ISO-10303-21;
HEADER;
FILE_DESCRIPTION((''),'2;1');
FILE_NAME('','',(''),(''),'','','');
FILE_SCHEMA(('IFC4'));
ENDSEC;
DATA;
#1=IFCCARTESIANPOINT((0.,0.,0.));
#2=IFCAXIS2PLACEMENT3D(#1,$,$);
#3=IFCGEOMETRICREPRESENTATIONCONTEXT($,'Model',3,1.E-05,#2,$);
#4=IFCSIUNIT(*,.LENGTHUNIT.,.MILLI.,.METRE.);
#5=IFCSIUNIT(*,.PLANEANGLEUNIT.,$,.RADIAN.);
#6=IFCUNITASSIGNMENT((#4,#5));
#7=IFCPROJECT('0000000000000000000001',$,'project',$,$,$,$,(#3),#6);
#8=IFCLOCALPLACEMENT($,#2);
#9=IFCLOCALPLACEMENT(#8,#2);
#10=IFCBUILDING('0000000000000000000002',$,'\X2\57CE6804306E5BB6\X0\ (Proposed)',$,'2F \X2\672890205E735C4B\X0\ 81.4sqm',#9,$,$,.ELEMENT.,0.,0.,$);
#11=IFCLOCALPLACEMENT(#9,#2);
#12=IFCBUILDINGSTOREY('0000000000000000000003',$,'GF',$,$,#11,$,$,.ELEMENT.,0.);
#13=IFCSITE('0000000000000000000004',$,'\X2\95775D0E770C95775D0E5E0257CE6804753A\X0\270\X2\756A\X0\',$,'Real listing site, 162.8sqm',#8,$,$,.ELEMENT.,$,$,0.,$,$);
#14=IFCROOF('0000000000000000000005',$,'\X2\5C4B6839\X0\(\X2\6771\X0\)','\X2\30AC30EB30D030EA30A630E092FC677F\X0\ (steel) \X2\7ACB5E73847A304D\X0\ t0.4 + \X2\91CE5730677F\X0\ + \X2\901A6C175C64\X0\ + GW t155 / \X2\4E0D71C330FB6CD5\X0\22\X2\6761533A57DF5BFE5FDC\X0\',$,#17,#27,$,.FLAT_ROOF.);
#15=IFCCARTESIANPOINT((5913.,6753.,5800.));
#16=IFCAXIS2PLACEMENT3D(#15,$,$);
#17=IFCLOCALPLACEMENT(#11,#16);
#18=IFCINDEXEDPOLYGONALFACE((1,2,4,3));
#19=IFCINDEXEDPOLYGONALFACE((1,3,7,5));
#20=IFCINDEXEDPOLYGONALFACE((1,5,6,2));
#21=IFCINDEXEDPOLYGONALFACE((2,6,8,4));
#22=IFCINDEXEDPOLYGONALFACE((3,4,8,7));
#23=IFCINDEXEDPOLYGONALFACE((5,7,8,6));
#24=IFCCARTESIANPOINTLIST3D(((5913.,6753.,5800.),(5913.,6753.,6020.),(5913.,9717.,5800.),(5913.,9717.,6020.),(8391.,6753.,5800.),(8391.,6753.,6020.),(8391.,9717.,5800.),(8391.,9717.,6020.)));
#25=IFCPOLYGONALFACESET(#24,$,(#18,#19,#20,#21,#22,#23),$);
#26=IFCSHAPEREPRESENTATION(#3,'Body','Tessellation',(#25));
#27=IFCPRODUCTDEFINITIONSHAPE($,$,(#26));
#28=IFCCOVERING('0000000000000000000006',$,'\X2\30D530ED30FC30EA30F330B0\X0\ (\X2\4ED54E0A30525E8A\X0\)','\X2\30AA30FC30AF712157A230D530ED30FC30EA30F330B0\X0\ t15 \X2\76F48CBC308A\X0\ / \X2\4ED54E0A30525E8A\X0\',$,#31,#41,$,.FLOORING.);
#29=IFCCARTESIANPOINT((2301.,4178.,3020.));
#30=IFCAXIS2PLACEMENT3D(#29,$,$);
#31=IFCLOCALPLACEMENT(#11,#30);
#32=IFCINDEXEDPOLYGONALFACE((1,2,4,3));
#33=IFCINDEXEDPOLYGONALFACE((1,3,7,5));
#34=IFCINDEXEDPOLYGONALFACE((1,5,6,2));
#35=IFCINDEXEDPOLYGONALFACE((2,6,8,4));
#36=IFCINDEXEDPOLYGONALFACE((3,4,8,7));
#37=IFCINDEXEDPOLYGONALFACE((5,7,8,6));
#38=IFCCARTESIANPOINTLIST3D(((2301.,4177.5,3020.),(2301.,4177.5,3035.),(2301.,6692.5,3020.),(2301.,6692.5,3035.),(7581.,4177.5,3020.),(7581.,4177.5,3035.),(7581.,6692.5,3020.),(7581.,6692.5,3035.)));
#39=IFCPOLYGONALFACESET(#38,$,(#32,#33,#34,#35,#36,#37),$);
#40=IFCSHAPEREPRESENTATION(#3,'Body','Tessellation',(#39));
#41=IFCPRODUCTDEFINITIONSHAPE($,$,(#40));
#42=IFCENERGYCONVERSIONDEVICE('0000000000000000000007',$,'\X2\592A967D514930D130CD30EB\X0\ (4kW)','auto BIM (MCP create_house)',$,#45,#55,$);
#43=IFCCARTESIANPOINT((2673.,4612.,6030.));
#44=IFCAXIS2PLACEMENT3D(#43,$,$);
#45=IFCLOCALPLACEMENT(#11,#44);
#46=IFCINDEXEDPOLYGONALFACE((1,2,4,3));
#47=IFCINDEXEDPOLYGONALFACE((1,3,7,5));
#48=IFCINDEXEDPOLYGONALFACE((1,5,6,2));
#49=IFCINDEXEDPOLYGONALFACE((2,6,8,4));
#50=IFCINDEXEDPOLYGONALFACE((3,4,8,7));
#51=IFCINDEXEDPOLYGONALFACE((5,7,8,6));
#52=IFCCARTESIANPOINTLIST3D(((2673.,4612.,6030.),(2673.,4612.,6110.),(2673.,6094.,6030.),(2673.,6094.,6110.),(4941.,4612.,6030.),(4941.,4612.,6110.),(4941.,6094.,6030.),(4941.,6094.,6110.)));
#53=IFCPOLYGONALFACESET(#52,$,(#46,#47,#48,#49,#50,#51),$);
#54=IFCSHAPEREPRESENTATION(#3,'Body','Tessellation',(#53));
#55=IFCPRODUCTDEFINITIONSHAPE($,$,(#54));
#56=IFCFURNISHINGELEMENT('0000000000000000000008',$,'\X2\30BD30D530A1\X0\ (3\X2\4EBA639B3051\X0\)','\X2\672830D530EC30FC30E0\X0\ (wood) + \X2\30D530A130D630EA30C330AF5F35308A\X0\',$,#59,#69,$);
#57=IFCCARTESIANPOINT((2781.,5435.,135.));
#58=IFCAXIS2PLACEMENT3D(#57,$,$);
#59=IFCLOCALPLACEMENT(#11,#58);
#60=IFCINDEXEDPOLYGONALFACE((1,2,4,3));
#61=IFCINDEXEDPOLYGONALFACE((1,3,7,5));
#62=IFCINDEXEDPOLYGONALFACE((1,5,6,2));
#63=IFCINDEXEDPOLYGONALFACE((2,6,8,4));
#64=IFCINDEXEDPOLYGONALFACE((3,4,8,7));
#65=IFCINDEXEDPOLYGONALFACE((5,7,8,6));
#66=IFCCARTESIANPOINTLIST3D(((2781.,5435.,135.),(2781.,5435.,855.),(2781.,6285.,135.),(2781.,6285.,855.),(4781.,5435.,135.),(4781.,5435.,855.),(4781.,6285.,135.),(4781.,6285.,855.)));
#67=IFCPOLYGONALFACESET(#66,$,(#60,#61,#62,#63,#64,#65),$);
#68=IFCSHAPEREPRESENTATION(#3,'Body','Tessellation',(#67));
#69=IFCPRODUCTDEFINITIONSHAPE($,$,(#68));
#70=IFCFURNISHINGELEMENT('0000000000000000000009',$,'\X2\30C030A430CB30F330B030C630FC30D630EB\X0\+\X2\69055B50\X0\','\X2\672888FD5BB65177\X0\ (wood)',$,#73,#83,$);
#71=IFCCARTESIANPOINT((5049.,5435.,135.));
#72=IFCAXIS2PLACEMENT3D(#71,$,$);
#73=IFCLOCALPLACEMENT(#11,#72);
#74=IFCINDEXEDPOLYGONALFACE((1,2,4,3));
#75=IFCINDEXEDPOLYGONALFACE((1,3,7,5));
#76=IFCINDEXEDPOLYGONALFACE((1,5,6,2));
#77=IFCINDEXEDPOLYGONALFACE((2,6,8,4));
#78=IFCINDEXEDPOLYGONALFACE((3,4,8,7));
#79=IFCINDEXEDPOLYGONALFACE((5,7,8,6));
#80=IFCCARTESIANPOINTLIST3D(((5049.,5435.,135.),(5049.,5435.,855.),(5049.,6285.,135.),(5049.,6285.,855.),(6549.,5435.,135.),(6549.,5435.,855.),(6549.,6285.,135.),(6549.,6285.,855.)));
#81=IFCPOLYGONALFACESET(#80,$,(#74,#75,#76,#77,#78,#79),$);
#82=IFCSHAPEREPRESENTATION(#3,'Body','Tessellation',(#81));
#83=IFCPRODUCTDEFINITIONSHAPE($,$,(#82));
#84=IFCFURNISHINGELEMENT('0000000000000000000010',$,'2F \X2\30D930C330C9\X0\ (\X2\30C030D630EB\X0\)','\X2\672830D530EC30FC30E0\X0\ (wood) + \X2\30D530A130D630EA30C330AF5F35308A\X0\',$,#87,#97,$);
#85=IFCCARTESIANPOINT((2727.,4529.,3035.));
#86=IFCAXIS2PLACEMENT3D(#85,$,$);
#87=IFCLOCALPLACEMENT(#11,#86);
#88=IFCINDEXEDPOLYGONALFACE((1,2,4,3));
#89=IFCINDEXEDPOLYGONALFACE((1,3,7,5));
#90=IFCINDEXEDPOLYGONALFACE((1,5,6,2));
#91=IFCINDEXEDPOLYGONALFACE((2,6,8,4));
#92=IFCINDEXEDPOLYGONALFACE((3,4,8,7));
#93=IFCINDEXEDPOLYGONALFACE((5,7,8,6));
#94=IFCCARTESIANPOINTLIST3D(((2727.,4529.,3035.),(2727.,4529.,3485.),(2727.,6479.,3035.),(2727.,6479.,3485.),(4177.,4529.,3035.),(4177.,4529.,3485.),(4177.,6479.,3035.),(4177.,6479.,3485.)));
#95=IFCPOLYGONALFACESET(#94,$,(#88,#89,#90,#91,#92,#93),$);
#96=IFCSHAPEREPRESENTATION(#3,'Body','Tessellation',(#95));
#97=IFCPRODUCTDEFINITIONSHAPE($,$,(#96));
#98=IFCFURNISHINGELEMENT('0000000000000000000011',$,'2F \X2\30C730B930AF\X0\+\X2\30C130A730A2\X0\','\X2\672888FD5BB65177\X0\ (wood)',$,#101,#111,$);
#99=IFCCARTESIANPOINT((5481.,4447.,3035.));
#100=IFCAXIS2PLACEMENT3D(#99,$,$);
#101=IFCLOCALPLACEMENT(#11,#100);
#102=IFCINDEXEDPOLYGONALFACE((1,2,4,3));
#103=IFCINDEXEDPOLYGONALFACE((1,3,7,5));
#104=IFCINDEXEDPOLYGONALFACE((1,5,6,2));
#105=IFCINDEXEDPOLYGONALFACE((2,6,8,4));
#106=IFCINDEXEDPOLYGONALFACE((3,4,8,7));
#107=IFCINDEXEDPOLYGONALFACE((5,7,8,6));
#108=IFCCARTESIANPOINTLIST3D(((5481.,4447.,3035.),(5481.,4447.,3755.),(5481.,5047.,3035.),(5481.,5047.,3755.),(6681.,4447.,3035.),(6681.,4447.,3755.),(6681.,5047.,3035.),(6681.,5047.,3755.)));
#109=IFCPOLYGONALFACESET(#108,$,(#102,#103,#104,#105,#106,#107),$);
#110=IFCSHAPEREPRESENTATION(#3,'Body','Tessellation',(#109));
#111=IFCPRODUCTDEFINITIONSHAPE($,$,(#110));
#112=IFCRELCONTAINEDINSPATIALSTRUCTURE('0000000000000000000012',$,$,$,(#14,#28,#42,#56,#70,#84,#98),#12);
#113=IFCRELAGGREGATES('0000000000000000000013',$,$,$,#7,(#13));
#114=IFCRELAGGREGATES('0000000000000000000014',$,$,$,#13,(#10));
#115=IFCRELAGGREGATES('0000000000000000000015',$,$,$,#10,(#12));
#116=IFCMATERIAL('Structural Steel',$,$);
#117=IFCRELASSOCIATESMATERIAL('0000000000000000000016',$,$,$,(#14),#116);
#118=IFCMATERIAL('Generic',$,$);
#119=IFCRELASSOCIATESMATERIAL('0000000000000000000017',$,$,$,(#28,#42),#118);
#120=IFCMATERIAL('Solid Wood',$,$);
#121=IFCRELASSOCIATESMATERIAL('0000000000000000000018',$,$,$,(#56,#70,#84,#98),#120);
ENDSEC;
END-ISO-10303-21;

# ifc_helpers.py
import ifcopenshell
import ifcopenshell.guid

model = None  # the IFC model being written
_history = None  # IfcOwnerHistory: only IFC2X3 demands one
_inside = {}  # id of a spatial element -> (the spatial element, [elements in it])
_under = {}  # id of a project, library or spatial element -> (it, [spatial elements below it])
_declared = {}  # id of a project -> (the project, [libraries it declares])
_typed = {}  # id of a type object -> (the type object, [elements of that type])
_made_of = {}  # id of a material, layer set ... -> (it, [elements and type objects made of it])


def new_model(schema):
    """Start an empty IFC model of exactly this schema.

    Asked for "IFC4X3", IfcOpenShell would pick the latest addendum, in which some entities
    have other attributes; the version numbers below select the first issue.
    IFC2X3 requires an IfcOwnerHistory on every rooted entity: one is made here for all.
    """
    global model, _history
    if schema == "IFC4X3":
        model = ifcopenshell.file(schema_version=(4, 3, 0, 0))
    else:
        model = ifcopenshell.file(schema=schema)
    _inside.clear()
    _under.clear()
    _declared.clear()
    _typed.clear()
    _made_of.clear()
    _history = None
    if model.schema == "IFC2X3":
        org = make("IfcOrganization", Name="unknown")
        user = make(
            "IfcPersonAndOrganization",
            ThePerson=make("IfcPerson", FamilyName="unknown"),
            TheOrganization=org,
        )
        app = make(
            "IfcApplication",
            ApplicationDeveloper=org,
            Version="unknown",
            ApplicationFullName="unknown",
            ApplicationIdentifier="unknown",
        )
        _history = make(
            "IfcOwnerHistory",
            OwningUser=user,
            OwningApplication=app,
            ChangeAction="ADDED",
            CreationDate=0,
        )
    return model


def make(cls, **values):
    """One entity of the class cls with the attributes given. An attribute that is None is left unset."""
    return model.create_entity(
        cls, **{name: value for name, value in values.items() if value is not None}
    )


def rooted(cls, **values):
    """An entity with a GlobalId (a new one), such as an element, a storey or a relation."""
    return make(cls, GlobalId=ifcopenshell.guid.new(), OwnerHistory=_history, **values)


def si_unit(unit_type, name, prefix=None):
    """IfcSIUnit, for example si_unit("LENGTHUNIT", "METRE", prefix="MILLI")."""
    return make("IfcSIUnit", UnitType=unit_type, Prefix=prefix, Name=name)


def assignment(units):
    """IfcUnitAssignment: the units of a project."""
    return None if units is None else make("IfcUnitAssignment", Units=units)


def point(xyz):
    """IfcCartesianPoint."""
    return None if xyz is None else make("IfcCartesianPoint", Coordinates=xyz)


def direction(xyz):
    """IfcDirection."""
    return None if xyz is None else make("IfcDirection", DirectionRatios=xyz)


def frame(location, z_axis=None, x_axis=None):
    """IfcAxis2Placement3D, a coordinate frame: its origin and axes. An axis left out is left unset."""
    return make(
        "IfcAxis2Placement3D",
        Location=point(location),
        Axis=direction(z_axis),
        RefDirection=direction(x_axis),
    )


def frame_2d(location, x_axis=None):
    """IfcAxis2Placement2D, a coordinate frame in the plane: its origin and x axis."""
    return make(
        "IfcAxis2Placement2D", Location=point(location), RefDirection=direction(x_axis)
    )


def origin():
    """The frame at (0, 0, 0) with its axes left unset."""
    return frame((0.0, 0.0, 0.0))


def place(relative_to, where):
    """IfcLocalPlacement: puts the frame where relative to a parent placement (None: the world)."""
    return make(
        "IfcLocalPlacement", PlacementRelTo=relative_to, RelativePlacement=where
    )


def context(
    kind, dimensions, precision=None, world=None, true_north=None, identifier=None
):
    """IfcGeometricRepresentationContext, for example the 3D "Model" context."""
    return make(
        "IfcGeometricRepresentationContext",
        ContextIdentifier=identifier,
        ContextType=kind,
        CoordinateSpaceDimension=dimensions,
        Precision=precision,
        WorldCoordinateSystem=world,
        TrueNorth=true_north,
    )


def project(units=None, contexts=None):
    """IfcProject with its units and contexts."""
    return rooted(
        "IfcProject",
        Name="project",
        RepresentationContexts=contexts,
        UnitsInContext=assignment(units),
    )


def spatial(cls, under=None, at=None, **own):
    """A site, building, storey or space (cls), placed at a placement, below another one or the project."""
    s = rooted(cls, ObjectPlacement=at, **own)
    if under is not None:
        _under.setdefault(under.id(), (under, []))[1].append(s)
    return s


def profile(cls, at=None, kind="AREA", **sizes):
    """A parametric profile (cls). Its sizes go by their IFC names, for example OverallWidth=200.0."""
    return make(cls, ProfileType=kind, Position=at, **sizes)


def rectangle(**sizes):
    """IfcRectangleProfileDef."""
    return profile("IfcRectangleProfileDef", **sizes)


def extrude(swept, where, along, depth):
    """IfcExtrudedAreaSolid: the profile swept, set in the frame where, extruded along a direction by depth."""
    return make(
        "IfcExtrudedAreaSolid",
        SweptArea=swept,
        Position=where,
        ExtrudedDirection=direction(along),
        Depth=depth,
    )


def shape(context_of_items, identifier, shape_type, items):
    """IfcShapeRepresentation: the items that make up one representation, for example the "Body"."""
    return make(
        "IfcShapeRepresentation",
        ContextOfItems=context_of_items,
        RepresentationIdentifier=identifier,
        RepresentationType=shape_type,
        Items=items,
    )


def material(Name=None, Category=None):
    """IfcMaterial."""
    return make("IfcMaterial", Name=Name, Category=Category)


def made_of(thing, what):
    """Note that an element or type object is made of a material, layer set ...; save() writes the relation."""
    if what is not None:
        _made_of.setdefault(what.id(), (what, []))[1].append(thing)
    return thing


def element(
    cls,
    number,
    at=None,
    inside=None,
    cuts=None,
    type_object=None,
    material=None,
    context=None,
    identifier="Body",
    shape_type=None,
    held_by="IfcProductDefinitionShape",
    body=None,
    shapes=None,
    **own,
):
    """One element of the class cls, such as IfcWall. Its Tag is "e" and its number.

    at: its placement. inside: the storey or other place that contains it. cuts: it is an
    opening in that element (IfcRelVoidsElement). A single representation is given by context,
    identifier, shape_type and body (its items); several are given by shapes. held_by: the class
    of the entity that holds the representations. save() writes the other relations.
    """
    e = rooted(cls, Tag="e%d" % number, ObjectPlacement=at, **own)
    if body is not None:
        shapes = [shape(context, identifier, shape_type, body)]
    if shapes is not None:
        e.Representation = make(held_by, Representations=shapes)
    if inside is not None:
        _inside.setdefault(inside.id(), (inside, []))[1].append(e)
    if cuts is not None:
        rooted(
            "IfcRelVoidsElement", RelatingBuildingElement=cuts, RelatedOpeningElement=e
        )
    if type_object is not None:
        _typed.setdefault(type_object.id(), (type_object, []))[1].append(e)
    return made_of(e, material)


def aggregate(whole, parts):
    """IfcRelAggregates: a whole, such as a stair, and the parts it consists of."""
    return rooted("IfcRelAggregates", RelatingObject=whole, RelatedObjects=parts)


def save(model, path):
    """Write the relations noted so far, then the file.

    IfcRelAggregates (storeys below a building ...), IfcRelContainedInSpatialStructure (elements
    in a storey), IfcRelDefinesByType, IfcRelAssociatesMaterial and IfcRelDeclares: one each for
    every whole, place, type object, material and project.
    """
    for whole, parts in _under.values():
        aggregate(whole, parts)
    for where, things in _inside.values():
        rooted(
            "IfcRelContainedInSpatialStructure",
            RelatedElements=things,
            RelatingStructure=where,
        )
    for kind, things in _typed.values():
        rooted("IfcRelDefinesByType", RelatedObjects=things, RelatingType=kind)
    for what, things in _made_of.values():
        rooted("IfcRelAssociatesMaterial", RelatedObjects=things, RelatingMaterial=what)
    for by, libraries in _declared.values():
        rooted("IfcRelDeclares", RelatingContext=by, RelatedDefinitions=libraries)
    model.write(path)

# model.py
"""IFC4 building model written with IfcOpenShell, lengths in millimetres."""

from ifc_helpers import new_model, si_unit, frame, frame_2d, origin, place, context, project, spatial, rectangle, extrude, material, element, save


model = new_model("IFC4")

# Units and contexts
model_context = context("Model", 3, precision=1e-05, world=origin())
ifc_project = project(units=[si_unit("LENGTHUNIT", "METRE", prefix="MILLI"), si_unit("PLANEANGLEUNIT", "RADIAN")], contexts=[model_context])

# Site, building, storey
site_placement = place(None, origin())
site = spatial("IfcSite", under=ifc_project, at=site_placement, Name="長崎県長崎市城栄町270番", ObjectType="Real listing site, 162.8sqm", CompositionType="ELEMENT", RefElevation=0.0)
building_placement = place(site_placement, origin())
building = spatial("IfcBuilding", under=site, at=building_placement, Name="城栄の家 (Proposed)", ObjectType="2F 木造平屋 81.4sqm", CompositionType="ELEMENT", ElevationOfRefHeight=0.0, ElevationOfTerrain=0.0)
storey_placement = place(building_placement, origin())
storey = spatial("IfcBuildingStorey", under=building, at=storey_placement, Name="GF", CompositionType="ELEMENT", Elevation=0.0)

# Shared definitions
ifc_material_1 = material(Name="Solid Wood")

# Roof
ifc_material_2 = material(Name="Structural Steel")
roof_1_placement = place(storey_placement, frame((5913.0, 6753.0, 5800.0)))
element("IfcRoof", 1, at=roof_1_placement, inside=storey, material=ifc_material_2, Name="屋根(東)", Description="ガルバリウム鋼板 (steel) 立平葺き t0.4 + 野地板 + 通気層 + GW t155 / 不燃・法22条区域対応", PredefinedType="FLAT_ROOF", context=model_context, shape_type="SweptSolid", body=[
    extrude(rectangle(XDim=2478.0, YDim=2964.0, at=frame_2d((1239.0, 1482.0))), frame((5913.0, 6753.0, 5800.0)), (0.0, 0.0, 1.0), 220.0),
])

# Covering
ifc_material_3 = material(Name="Generic")
covering_placement = place(storey_placement, frame((2301.0, 4178.0, 3020.0)))
element("IfcCovering", 2, at=covering_placement, inside=storey, material=ifc_material_3, Name="フローリング (仕上げ床)", Description="オーク無垢フローリング t15 直貼り / 仕上げ床", PredefinedType="FLOORING", context=model_context, shape_type="SweptSolid", body=[
    extrude(rectangle(XDim=5280.0, YDim=2515.0, at=frame_2d((2640.0, 1257.0))), frame((2301.0, 4178.0, 3020.0)), (0.0, 0.0, 1.0), 15.0),
])

# Energy conversion device
energy_conversion_device_placement = place(storey_placement, frame((2673.0, 4612.0, 6030.0)))
element("IfcEnergyConversionDevice", 3, at=energy_conversion_device_placement, inside=storey, material=ifc_material_3, Name="太陽光パネル (4kW)", Description="auto BIM (MCP create_house)", context=model_context, shape_type="SweptSolid", body=[
    extrude(rectangle(XDim=2268.0, YDim=1482.0, at=frame_2d((1134.0, 741.0))), frame((2673.0, 4612.0, 6030.0)), (0.0, 0.0, 1.0), 80.0),
])

# Furnishing elements
furnishing_1_placement = place(storey_placement, frame((2781.0, 5435.0, 135.0)))
element("IfcFurnishingElement", 4, at=furnishing_1_placement, inside=storey, material=ifc_material_1, Name="ソファ (3人掛け)", Description="木フレーム (wood) + ファブリック張り", context=model_context, shape_type="SweptSolid", body=[
    extrude(rectangle(XDim=2000.0, YDim=850.0, at=frame_2d((1000.0, 425.0))), frame((2781.0, 5435.0, 135.0)), (0.0, 0.0, 1.0), 720.0),
])
furnishing_2_placement = place(storey_placement, frame((5049.0, 5435.0, 135.0)))
element("IfcFurnishingElement", 5, at=furnishing_2_placement, inside=storey, material=ifc_material_1, Name="ダイニングテーブル+椅子", Description="木製家具 (wood)", context=model_context, shape_type="SweptSolid", body=[
    extrude(rectangle(XDim=1500.0, YDim=850.0, at=frame_2d((750.0, 425.0))), frame((5049.0, 5435.0, 135.0)), (0.0, 0.0, 1.0), 720.0),
])
furnishing_3_placement = place(storey_placement, frame((2727.0, 4529.0, 3035.0)))
element("IfcFurnishingElement", 6, at=furnishing_3_placement, inside=storey, material=ifc_material_1, Name="2F ベッド (ダブル)", Description="木フレーム (wood) + ファブリック張り", context=model_context, shape_type="SweptSolid", body=[
    extrude(rectangle(XDim=1450.0, YDim=1950.0, at=frame_2d((725.0, 975.0))), frame((2727.0, 4529.0, 3035.0)), (0.0, 0.0, 1.0), 450.0),
])
furnishing_4_placement = place(storey_placement, frame((5481.0, 4447.0, 3035.0)))
element("IfcFurnishingElement", 7, at=furnishing_4_placement, inside=storey, material=ifc_material_1, Name="2F デスク+チェア", Description="木製家具 (wood)", context=model_context, shape_type="SweptSolid", body=[
    extrude(rectangle(XDim=1200.0, YDim=600.0, at=frame_2d((600.0, 300.0))), frame((5481.0, 4447.0, 3035.0)), (0.0, 0.0, 1.0), 720.0),
])

save(model, "model.ifc")
